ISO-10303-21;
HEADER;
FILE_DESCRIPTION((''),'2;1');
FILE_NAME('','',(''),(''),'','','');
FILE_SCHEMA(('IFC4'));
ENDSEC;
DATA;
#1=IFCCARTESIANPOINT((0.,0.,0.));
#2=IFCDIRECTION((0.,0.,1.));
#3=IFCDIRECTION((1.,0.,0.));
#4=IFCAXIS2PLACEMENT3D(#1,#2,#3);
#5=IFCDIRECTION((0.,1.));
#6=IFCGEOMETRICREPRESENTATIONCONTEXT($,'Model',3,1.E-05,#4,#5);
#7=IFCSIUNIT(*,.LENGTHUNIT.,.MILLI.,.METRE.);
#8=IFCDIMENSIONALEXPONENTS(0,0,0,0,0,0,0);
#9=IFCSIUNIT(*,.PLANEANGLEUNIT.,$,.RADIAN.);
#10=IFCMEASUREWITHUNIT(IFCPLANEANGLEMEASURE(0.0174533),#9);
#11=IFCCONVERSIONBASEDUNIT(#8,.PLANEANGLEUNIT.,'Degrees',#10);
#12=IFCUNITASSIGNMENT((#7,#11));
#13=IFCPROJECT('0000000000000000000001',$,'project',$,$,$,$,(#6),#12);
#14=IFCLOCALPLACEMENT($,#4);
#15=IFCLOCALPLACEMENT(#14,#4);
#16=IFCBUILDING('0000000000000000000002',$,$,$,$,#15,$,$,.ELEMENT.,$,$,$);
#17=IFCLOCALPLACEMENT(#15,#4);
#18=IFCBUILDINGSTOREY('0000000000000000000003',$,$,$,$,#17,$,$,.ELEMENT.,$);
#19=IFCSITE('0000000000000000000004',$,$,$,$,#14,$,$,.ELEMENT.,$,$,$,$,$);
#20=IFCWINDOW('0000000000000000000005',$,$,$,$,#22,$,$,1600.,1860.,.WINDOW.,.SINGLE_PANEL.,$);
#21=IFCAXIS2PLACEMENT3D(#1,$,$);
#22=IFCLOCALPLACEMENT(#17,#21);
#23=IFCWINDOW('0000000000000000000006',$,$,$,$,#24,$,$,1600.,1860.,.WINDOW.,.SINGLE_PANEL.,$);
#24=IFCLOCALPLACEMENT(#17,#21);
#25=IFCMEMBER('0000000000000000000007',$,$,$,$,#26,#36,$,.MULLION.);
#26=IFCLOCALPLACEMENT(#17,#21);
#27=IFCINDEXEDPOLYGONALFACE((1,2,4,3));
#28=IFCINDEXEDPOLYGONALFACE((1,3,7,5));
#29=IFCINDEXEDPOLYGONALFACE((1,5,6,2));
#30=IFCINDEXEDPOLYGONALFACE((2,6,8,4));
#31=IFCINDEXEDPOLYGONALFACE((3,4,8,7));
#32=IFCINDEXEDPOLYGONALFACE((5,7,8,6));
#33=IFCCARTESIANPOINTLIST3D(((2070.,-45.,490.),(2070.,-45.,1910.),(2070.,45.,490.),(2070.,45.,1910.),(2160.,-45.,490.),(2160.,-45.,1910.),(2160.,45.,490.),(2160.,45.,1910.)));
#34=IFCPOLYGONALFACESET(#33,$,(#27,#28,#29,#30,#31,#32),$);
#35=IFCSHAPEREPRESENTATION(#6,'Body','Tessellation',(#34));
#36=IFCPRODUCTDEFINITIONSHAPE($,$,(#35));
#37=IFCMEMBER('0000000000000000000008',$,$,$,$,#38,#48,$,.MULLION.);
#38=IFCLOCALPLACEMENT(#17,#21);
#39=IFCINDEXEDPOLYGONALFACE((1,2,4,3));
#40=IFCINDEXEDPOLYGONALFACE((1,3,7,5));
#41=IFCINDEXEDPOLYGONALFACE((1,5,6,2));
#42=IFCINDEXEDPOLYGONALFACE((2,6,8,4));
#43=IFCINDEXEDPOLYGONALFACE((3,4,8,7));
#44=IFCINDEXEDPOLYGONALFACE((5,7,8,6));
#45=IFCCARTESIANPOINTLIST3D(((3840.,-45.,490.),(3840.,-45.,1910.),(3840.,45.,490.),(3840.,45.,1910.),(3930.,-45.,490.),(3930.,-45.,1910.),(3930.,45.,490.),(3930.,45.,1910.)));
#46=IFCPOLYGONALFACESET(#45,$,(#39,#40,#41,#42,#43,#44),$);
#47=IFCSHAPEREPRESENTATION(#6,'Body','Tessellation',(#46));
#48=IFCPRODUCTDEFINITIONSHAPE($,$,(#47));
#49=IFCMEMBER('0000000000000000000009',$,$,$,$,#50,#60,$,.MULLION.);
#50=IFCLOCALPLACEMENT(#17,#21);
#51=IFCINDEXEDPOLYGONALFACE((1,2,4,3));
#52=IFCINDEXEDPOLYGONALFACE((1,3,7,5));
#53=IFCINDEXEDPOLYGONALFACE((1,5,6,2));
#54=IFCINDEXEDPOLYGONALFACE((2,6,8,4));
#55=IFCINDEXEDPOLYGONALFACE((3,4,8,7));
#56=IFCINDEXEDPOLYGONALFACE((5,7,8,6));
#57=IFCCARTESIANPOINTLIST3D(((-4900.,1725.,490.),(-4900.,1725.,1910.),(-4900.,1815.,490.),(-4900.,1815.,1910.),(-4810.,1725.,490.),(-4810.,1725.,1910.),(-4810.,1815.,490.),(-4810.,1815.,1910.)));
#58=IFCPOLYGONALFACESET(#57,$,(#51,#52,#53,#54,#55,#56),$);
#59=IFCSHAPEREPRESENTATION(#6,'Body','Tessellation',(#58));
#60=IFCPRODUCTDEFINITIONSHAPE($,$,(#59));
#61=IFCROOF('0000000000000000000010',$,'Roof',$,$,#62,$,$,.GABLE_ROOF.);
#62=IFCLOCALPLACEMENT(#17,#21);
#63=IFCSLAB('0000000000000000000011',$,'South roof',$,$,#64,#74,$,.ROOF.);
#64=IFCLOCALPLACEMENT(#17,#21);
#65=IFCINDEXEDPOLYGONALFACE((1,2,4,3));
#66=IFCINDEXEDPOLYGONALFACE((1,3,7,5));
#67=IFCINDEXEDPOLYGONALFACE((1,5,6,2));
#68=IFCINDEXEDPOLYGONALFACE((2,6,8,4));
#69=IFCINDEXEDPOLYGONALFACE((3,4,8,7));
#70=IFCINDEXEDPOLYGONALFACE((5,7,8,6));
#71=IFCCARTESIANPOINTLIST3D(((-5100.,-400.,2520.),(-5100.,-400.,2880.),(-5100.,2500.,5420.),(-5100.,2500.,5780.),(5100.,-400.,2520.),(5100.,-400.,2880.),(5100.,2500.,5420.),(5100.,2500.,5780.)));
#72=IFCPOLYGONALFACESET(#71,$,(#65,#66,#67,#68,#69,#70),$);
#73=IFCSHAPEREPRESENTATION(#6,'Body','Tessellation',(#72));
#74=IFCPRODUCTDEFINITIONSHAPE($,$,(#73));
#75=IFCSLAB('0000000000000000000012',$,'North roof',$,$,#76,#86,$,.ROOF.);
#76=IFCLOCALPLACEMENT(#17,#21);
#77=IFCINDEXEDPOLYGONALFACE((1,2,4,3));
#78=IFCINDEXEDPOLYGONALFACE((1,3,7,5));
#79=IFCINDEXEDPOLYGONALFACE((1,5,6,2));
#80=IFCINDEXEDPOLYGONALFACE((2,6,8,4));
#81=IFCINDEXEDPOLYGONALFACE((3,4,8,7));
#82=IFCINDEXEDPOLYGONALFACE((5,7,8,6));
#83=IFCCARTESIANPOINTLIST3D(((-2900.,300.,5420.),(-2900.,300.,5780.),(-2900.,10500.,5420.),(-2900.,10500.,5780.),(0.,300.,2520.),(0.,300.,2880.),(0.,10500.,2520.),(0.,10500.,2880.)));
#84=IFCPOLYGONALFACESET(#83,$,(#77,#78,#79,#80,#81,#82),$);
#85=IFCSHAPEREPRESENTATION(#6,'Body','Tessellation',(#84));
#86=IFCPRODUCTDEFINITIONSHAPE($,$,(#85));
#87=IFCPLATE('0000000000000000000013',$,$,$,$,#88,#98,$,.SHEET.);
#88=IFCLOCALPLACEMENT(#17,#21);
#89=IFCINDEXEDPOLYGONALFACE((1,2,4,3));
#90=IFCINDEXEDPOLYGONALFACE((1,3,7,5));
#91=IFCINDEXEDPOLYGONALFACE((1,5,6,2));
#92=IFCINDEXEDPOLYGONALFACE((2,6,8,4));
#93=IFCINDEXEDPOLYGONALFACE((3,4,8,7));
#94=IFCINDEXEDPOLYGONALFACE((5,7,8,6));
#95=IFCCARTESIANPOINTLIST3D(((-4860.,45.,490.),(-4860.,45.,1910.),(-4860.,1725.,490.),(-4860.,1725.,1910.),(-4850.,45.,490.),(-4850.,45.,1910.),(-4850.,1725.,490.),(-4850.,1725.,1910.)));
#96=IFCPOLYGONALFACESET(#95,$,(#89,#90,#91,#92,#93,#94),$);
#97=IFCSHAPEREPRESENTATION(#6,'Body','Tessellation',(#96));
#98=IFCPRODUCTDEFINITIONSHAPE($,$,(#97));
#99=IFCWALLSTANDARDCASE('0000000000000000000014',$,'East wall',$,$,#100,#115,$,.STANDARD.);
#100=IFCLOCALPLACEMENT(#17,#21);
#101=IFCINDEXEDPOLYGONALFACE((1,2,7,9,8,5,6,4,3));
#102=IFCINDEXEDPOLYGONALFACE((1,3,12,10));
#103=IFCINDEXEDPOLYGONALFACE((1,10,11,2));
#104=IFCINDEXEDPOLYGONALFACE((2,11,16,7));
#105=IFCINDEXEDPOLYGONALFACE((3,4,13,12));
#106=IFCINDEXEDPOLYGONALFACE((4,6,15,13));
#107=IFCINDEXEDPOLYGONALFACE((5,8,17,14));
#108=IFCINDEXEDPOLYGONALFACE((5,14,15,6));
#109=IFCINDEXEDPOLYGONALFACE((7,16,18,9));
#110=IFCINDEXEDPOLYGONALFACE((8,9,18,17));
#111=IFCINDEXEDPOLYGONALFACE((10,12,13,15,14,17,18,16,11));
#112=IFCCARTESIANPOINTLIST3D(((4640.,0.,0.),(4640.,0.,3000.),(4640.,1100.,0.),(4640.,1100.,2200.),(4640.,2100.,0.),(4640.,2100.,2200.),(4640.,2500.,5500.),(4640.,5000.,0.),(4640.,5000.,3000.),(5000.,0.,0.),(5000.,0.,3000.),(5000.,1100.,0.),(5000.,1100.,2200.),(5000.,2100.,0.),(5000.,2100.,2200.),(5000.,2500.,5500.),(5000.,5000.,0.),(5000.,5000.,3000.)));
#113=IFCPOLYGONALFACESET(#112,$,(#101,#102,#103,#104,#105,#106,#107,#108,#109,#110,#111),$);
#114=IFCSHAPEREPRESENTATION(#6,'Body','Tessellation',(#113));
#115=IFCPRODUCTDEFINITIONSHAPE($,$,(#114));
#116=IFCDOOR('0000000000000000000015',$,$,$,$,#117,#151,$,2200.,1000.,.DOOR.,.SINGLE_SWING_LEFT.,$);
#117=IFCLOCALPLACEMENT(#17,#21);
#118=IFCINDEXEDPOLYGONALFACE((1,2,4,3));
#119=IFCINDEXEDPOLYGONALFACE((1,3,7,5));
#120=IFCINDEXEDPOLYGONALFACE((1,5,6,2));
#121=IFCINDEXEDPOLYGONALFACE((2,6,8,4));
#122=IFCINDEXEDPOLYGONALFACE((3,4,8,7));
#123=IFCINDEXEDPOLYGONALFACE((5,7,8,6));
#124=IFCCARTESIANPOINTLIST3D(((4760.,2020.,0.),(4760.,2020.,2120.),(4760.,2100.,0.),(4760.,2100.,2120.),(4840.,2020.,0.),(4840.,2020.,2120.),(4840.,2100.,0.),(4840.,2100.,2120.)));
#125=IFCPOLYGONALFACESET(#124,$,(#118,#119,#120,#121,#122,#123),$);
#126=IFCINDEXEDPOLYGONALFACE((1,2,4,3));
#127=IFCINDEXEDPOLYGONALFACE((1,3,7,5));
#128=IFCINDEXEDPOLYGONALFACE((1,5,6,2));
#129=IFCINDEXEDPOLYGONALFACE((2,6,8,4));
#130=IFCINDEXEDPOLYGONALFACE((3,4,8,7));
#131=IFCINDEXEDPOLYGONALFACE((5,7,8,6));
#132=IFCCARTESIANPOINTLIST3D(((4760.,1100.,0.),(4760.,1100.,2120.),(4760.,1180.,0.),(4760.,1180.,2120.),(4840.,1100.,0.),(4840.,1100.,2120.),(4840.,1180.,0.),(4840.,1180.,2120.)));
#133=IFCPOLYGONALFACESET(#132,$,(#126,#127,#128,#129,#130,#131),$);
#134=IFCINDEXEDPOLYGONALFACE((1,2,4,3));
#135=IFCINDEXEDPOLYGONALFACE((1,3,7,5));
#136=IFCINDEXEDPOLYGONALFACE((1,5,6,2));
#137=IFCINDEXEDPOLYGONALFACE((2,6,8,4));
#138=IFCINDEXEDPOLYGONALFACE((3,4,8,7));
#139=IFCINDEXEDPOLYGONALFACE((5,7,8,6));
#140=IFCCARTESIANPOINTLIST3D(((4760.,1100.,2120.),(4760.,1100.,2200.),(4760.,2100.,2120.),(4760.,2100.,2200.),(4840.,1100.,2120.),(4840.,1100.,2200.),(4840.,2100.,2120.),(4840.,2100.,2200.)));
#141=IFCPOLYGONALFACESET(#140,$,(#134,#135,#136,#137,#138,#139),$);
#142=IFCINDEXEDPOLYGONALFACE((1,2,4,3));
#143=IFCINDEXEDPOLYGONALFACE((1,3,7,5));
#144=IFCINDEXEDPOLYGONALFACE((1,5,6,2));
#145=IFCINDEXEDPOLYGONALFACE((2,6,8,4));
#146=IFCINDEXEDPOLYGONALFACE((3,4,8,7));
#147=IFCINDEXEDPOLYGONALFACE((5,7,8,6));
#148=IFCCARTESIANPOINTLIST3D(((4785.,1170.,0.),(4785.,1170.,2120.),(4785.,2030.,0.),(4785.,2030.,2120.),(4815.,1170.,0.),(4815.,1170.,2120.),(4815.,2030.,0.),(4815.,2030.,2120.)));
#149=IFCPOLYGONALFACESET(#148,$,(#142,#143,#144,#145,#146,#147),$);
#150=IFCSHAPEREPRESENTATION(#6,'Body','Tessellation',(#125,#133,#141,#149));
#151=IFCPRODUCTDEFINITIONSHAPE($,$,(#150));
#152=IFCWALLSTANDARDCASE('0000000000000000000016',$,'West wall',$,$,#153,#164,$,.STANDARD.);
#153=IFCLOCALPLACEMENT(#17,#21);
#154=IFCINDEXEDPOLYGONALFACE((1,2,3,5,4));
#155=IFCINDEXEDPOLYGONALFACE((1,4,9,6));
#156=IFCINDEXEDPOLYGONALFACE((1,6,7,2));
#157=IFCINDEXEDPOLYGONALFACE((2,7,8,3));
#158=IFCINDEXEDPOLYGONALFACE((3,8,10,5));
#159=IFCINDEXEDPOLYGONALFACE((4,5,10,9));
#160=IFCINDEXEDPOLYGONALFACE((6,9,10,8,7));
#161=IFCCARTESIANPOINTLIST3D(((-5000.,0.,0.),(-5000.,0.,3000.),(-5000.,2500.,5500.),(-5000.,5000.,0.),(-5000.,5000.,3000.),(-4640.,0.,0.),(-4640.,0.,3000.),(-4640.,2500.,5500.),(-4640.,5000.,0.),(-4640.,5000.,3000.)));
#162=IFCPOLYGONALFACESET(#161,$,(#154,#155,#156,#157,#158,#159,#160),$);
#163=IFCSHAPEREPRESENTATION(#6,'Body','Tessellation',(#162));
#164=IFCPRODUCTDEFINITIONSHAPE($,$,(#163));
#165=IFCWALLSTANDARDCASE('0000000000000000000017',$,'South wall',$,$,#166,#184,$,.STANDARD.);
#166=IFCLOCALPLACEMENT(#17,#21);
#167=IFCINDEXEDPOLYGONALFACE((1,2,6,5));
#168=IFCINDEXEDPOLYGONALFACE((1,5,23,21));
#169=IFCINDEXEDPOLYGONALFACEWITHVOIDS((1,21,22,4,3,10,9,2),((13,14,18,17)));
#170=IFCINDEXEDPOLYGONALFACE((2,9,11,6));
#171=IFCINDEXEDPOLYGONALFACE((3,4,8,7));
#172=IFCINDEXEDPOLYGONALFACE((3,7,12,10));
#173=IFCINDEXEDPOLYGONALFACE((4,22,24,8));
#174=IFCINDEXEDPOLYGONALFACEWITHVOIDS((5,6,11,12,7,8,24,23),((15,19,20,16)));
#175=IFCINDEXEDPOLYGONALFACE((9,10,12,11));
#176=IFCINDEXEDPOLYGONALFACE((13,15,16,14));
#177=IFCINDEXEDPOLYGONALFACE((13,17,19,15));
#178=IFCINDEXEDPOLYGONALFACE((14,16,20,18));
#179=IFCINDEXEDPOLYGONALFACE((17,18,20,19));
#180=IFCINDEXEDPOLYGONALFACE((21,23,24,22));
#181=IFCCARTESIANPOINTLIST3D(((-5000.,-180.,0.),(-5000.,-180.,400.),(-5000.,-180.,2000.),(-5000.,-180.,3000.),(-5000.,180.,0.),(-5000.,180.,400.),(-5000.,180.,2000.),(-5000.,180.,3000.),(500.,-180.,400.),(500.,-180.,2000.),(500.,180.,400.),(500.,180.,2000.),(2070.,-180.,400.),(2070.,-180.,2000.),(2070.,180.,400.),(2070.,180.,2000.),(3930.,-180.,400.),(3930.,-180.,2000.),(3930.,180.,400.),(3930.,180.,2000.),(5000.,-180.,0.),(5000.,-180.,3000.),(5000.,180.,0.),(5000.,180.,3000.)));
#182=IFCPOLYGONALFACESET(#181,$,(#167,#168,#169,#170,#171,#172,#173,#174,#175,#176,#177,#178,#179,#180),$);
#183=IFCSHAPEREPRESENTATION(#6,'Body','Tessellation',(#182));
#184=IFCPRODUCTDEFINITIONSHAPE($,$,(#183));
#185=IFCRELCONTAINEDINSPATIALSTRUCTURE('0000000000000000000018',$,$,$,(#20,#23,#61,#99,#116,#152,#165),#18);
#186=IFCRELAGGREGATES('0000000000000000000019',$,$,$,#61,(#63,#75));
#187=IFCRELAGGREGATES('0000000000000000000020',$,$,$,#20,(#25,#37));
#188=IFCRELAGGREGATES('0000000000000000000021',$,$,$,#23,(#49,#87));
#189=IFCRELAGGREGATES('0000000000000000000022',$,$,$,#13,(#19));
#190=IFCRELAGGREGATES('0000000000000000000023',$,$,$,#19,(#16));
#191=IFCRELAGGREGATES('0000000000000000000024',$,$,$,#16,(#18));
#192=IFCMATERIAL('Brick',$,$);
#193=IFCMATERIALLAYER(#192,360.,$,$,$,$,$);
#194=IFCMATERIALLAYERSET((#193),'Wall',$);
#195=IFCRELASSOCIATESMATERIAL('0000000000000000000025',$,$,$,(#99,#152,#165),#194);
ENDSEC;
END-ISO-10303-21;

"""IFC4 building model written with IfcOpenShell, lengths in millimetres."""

from ifc_helpers import new_model, entity, si_unit, converted_unit, direction, frame, origin_with_axes, place, context, project, spatial, polyline, outline, extrude, clip, halfspace, source, transform, mapped, material, layer, layer_set, layer_usage, element, fill, aggregate, save


model = new_model("IFC4")

# Units and contexts
model_context = context("Model", 3, precision=1e-05, world=origin_with_axes(), true_north=direction((0.0, 1.0)))
ifc_project = project(units=[si_unit("LENGTHUNIT", "METRE", prefix="MILLI"), converted_unit("PLANEANGLEUNIT", "Degrees", entity("IfcPlaneAngleMeasure", 0.0174533), si_unit("PLANEANGLEUNIT", "RADIAN"), dimensions=[0, 0, 0, 0, 0, 0, 0])], contexts=[model_context])

# Site, building, storey
site_placement = place(None, origin_with_axes())
site = spatial("IfcSite", under=ifc_project, at=site_placement, CompositionType="ELEMENT")
building_placement = place(site_placement, origin_with_axes())
building = spatial("IfcBuilding", under=site, at=building_placement, CompositionType="ELEMENT")
storey_placement = place(building_placement, origin_with_axes())
storey = spatial("IfcBuildingStorey", under=building, at=storey_placement, CompositionType="ELEMENT")

# Windows
window_1_placement = place(storey_placement, frame((2070.0, -45.0, 400.0), z_axis=(0.0, 0.0, 1.0), x_axis=(1.0, 0.0, 0.0)))
window_1 = element("IfcWindow", 1, at=window_1_placement, inside=storey, OverallHeight=1600.0, OverallWidth=1860.0, PartitioningType="SINGLE_PANEL", PredefinedType="WINDOW")
window_2_placement = place(storey_placement, frame((-4810.0, -45.0, 400.0), z_axis=(0.0, 0.0, 1.0), x_axis=(0.0, 1.0, 0.0)))
window_2 = element("IfcWindow", 2, at=window_2_placement, inside=storey, OverallHeight=1600.0, OverallWidth=1860.0, PartitioningType="SINGLE_PANEL", PredefinedType="WINDOW")

# Members
shared_shape_1 = source(origin_with_axes(), model_context, "Body", "SweptSolid", [
    extrude(outline(polyline([(-45.0, -45.0), (45.0, -45.0), (45.0, 45.0), (-45.0, 45.0), (-45.0, -45.0), (-45.0, -45.0)])), origin_with_axes(), (0.0, 0.0, 1.0), 1420.0),
])
member_1_placement = place(window_1_placement, frame((45.0, 45.0, 90.0), z_axis=(0.0, 0.0, 1.0), x_axis=(1.0, 0.0, 0.0)))
member_1 = element("IfcMember", 3, at=member_1_placement, PredefinedType="MULLION", context=model_context, shape_type="MappedRepresentation", body=[
    mapped(shared_shape_1, transform((0.0, 0.0, 0.0))),
])
member_2_placement = place(window_1_placement, frame((1815.0, 45.0, 90.0), z_axis=(0.0, 0.0, 1.0), x_axis=(1.0, 0.0, 0.0)))
member_2 = element("IfcMember", 4, at=member_2_placement, PredefinedType="MULLION", context=model_context, shape_type="MappedRepresentation", body=[
    mapped(shared_shape_1, transform((0.0, 0.0, 0.0))),
])
member_3_placement = place(window_2_placement, frame((1815.0, 45.0, 90.0), z_axis=(0.0, 0.0, 1.0), x_axis=(1.0, 0.0, 0.0)))
member_3 = element("IfcMember", 5, at=member_3_placement, PredefinedType="MULLION", context=model_context, shape_type="MappedRepresentation", body=[
    mapped(shared_shape_1, transform((0.0, 0.0, 0.0))),
])

# Roof, slabs
roof_placement = place(storey_placement, origin_with_axes())
roof = element("IfcRoof", 6, at=roof_placement, inside=storey, Name="Roof", PredefinedType="GABLE_ROOF")
shared_shape_2 = source(origin_with_axes(), model_context, "Body", "SweptSolid", [
    extrude(outline(polyline([(-5100.0, -180.0), (5100.0, -180.0), (5100.0, 180.0), (-5100.0, 180.0), (-5100.0, -180.0), (-5100.0, -180.0)])), frame((0.0, 0.0, 0.0), z_axis=(0.0, 1.0, 0.0), x_axis=(1.0, 0.0, 0.0)), (0.0, -0.707107, 0.707107), 4101.2),
])
slab_1_placement = place(roof_placement, frame((0.0, -400.0, 2700.0), z_axis=(0.0, 0.0, 1.0), x_axis=(1.0, 0.0, 0.0)))
slab_1 = element("IfcSlab", 7, at=slab_1_placement, Name="South roof", PredefinedType="ROOF", context=model_context, shape_type="MappedRepresentation", body=[
    mapped(shared_shape_2, transform((0.0, 0.0, 0.0))),
])
slab_2_placement = place(roof_placement, frame((0.0, 5400.0, 2700.0), z_axis=(0.0, 0.0, 1.0), x_axis=(0.0, 1.0, 0.0)))
slab_2 = element("IfcSlab", 8, at=slab_2_placement, Name="North roof", PredefinedType="ROOF", context=model_context, shape_type="MappedRepresentation", body=[
    mapped(shared_shape_2, transform((0.0, 0.0, 0.0))),
])
aggregate(roof, [slab_1, slab_2])

# Plate
aggregate(window_1, [member_1, member_2])
plate_1_placement = place(window_2_placement, frame((930.0, 45.0, 90.0), z_axis=(0.0, 0.0, 1.0), x_axis=(1.0, 0.0, 0.0)))
plate_1 = element("IfcPlate", 9, at=plate_1_placement, PredefinedType="SHEET", context=model_context, shape_type="SweptSolid", body=[
    extrude(outline(polyline([(-840.0, -5.0), (840.0, -5.0), (840.0, 5.0), (-840.0, 5.0), (-840.0, -5.0), (-840.0, -5.0)])), origin_with_axes(), (0.0, 0.0, 1.0), 1420.0),
])
aggregate(window_2, [member_3, plate_1])

# Wall, opening, door
ifc_material = material(Name="Brick")
ifc_layer = layer(ifc_material, 360.0)
ifc_layer_set = layer_set([ifc_layer], Name="Wall")
ifc_layer_usage = layer_usage(ifc_layer_set, "AXIS2", "POSITIVE", -180.0)
shared_shape_3 = source(origin_with_axes(), model_context, "Body", "Clipping", [
    clip(clip(extrude(outline(polyline([(-2500.0, -180.0), (2500.0, -180.0), (2500.0, 180.0), (-2500.0, 180.0), (-2500.0, -180.0), (-2500.0, -180.0)])), origin_with_axes(), (0.0, 0.0, 1.0), 6000.0), halfspace(frame((-2500.0, 0.0, 3000.0), z_axis=(-1.0, 0.0, 1.0), x_axis=(1.0, 0.0, 0.0)), False)), halfspace(frame((2500.0, 0.0, 3000.0), z_axis=(1.0, 0.0, 1.0), x_axis=(1.0, 0.0, 0.0)), False)),
])
wall_1_placement = place(storey_placement, frame((4820.0, 2500.0, 0.0), z_axis=(0.0, 0.0, 1.0), x_axis=(0.0, 1.0, 0.0)))
wall_1 = element("IfcWallStandardCase", 10, at=wall_1_placement, inside=storey, material=ifc_layer_usage, Name="East wall", PredefinedType="STANDARD", context=model_context, shape_type="MappedRepresentation", body=[
    mapped(shared_shape_3, transform((0.0, 0.0, 0.0))),
])
opening_1_placement = place(storey_placement, frame((4820.0, 1600.0, 0.0), z_axis=(0.0, 0.0, 1.0), x_axis=(1.0, 0.0, 0.0)))
opening_1 = element("IfcOpeningElement", 11, at=opening_1_placement, cuts=wall_1, PredefinedType="OPENING", context=model_context, shape_type="SweptSolid", body=[
    extrude(outline(polyline([(-500.0, -500.0), (500.0, -500.0), (500.0, 500.0), (-500.0, 500.0), (-500.0, -500.0), (-500.0, -500.0)])), origin_with_axes(), (0.0, 0.0, 1.0), 2200.0),
])
door_placement = place(storey_placement, frame((4800.0, 1600.0, 0.0), z_axis=(0.0, 0.0, 1.0), x_axis=(0.0, 1.0, 0.0)))
door = element("IfcDoor", 12, at=door_placement, inside=storey, OperationType="SINGLE_SWING_LEFT", OverallHeight=2200.0, OverallWidth=1000.0, PredefinedType="DOOR", context=model_context, shape_type="SweptSolid", body=[
    extrude(outline(polyline([(-40.0, -40.0), (40.0, -40.0), (40.0, 40.0), (-40.0, 40.0), (-40.0, -40.0), (-40.0, -40.0)])), frame((460.0, 0.0, 0.0), z_axis=(0.0, 0.0, 1.0), x_axis=(1.0, 0.0, 0.0)), (0.0, 0.0, 1.0), 2120.0),
    extrude(outline(polyline([(-40.0, -40.0), (40.0, -40.0), (40.0, 40.0), (-40.0, 40.0), (-40.0, -40.0), (-40.0, -40.0)])), frame((-460.0, 0.0, 0.0), z_axis=(0.0, 0.0, 1.0), x_axis=(1.0, 0.0, 0.0)), (0.0, 0.0, 1.0), 2120.0),
    extrude(outline(polyline([(-500.0, -40.0), (500.0, -40.0), (500.0, 40.0), (-500.0, 40.0), (-500.0, -40.0), (-500.0, -40.0)])), frame((0.0, 0.0, 2120.0), z_axis=(0.0, 0.0, 1.0), x_axis=(1.0, 0.0, 0.0)), (0.0, 0.0, 1.0), 80.0),
    extrude(outline(polyline([(-430.0, -15.0), (430.0, -15.0), (430.0, 15.0), (-430.0, 15.0), (-430.0, -15.0), (-430.0, -15.0)])), origin_with_axes(), (0.0, 0.0, 1.0), 2120.0),
])
fill(opening_1, door)

# Wall
wall_2_placement = place(storey_placement, frame((-4820.0, 2500.0, 0.0), z_axis=(0.0, 0.0, 1.0), x_axis=(0.0, -1.0, 0.0)))
element("IfcWallStandardCase", 13, at=wall_2_placement, inside=storey, material=ifc_layer_usage, Name="West wall", PredefinedType="STANDARD", context=model_context, shape_type="MappedRepresentation", body=[
    mapped(shared_shape_3, transform((0.0, 0.0, 0.0))),
])

# Wall, openings
wall_3_placement = place(storey_placement, origin_with_axes())
wall_3 = element("IfcWallStandardCase", 14, at=wall_3_placement, inside=storey, material=ifc_layer_usage, Name="South wall", PredefinedType="STANDARD", context=model_context, shape_type="SweptSolid", body=[
    extrude(outline(polyline([(-5000.0, -180.0), (5000.0, -180.0), (5000.0, 180.0), (-5000.0, 180.0), (-5000.0, -180.0), (-5000.0, -180.0)])), origin_with_axes(), (0.0, 0.0, 1.0), 3000.0),
])
opening_2_placement = place(wall_3_placement, frame((-2500.0, 0.0, 400.0), z_axis=(0.0, 0.0, 1.0), x_axis=(1.0, 0.0, 0.0)))
element("IfcOpeningElement", 15, at=opening_2_placement, cuts=wall_3, PredefinedType="OPENING", context=model_context, shape_type="SweptSolid", body=[
    extrude(outline(polyline([(-3000.0, -1815.0), (3000.0, -1815.0), (3000.0, 1815.0), (-3000.0, 1815.0), (-3000.0, -1815.0), (-3000.0, -1815.0)])), origin_with_axes(), (0.0, 0.0, 1.0), 1600.0),
])
opening_3_placement = place(storey_placement, frame((3000.0, 0.0, 400.0), z_axis=(0.0, 0.0, 1.0), x_axis=(1.0, 0.0, 0.0)))
element("IfcOpeningElement", 16, at=opening_3_placement, cuts=wall_3, PredefinedType="OPENING", context=model_context, shape_type="SweptSolid", body=[
    extrude(outline(polyline([(-930.0, -1500.0), (930.0, -1500.0), (930.0, 1500.0), (-930.0, 1500.0), (-930.0, -1500.0), (-930.0, -1500.0)])), origin_with_axes(), (0.0, 0.0, 1.0), 1600.0),
])

save(model, "model.ifc")
